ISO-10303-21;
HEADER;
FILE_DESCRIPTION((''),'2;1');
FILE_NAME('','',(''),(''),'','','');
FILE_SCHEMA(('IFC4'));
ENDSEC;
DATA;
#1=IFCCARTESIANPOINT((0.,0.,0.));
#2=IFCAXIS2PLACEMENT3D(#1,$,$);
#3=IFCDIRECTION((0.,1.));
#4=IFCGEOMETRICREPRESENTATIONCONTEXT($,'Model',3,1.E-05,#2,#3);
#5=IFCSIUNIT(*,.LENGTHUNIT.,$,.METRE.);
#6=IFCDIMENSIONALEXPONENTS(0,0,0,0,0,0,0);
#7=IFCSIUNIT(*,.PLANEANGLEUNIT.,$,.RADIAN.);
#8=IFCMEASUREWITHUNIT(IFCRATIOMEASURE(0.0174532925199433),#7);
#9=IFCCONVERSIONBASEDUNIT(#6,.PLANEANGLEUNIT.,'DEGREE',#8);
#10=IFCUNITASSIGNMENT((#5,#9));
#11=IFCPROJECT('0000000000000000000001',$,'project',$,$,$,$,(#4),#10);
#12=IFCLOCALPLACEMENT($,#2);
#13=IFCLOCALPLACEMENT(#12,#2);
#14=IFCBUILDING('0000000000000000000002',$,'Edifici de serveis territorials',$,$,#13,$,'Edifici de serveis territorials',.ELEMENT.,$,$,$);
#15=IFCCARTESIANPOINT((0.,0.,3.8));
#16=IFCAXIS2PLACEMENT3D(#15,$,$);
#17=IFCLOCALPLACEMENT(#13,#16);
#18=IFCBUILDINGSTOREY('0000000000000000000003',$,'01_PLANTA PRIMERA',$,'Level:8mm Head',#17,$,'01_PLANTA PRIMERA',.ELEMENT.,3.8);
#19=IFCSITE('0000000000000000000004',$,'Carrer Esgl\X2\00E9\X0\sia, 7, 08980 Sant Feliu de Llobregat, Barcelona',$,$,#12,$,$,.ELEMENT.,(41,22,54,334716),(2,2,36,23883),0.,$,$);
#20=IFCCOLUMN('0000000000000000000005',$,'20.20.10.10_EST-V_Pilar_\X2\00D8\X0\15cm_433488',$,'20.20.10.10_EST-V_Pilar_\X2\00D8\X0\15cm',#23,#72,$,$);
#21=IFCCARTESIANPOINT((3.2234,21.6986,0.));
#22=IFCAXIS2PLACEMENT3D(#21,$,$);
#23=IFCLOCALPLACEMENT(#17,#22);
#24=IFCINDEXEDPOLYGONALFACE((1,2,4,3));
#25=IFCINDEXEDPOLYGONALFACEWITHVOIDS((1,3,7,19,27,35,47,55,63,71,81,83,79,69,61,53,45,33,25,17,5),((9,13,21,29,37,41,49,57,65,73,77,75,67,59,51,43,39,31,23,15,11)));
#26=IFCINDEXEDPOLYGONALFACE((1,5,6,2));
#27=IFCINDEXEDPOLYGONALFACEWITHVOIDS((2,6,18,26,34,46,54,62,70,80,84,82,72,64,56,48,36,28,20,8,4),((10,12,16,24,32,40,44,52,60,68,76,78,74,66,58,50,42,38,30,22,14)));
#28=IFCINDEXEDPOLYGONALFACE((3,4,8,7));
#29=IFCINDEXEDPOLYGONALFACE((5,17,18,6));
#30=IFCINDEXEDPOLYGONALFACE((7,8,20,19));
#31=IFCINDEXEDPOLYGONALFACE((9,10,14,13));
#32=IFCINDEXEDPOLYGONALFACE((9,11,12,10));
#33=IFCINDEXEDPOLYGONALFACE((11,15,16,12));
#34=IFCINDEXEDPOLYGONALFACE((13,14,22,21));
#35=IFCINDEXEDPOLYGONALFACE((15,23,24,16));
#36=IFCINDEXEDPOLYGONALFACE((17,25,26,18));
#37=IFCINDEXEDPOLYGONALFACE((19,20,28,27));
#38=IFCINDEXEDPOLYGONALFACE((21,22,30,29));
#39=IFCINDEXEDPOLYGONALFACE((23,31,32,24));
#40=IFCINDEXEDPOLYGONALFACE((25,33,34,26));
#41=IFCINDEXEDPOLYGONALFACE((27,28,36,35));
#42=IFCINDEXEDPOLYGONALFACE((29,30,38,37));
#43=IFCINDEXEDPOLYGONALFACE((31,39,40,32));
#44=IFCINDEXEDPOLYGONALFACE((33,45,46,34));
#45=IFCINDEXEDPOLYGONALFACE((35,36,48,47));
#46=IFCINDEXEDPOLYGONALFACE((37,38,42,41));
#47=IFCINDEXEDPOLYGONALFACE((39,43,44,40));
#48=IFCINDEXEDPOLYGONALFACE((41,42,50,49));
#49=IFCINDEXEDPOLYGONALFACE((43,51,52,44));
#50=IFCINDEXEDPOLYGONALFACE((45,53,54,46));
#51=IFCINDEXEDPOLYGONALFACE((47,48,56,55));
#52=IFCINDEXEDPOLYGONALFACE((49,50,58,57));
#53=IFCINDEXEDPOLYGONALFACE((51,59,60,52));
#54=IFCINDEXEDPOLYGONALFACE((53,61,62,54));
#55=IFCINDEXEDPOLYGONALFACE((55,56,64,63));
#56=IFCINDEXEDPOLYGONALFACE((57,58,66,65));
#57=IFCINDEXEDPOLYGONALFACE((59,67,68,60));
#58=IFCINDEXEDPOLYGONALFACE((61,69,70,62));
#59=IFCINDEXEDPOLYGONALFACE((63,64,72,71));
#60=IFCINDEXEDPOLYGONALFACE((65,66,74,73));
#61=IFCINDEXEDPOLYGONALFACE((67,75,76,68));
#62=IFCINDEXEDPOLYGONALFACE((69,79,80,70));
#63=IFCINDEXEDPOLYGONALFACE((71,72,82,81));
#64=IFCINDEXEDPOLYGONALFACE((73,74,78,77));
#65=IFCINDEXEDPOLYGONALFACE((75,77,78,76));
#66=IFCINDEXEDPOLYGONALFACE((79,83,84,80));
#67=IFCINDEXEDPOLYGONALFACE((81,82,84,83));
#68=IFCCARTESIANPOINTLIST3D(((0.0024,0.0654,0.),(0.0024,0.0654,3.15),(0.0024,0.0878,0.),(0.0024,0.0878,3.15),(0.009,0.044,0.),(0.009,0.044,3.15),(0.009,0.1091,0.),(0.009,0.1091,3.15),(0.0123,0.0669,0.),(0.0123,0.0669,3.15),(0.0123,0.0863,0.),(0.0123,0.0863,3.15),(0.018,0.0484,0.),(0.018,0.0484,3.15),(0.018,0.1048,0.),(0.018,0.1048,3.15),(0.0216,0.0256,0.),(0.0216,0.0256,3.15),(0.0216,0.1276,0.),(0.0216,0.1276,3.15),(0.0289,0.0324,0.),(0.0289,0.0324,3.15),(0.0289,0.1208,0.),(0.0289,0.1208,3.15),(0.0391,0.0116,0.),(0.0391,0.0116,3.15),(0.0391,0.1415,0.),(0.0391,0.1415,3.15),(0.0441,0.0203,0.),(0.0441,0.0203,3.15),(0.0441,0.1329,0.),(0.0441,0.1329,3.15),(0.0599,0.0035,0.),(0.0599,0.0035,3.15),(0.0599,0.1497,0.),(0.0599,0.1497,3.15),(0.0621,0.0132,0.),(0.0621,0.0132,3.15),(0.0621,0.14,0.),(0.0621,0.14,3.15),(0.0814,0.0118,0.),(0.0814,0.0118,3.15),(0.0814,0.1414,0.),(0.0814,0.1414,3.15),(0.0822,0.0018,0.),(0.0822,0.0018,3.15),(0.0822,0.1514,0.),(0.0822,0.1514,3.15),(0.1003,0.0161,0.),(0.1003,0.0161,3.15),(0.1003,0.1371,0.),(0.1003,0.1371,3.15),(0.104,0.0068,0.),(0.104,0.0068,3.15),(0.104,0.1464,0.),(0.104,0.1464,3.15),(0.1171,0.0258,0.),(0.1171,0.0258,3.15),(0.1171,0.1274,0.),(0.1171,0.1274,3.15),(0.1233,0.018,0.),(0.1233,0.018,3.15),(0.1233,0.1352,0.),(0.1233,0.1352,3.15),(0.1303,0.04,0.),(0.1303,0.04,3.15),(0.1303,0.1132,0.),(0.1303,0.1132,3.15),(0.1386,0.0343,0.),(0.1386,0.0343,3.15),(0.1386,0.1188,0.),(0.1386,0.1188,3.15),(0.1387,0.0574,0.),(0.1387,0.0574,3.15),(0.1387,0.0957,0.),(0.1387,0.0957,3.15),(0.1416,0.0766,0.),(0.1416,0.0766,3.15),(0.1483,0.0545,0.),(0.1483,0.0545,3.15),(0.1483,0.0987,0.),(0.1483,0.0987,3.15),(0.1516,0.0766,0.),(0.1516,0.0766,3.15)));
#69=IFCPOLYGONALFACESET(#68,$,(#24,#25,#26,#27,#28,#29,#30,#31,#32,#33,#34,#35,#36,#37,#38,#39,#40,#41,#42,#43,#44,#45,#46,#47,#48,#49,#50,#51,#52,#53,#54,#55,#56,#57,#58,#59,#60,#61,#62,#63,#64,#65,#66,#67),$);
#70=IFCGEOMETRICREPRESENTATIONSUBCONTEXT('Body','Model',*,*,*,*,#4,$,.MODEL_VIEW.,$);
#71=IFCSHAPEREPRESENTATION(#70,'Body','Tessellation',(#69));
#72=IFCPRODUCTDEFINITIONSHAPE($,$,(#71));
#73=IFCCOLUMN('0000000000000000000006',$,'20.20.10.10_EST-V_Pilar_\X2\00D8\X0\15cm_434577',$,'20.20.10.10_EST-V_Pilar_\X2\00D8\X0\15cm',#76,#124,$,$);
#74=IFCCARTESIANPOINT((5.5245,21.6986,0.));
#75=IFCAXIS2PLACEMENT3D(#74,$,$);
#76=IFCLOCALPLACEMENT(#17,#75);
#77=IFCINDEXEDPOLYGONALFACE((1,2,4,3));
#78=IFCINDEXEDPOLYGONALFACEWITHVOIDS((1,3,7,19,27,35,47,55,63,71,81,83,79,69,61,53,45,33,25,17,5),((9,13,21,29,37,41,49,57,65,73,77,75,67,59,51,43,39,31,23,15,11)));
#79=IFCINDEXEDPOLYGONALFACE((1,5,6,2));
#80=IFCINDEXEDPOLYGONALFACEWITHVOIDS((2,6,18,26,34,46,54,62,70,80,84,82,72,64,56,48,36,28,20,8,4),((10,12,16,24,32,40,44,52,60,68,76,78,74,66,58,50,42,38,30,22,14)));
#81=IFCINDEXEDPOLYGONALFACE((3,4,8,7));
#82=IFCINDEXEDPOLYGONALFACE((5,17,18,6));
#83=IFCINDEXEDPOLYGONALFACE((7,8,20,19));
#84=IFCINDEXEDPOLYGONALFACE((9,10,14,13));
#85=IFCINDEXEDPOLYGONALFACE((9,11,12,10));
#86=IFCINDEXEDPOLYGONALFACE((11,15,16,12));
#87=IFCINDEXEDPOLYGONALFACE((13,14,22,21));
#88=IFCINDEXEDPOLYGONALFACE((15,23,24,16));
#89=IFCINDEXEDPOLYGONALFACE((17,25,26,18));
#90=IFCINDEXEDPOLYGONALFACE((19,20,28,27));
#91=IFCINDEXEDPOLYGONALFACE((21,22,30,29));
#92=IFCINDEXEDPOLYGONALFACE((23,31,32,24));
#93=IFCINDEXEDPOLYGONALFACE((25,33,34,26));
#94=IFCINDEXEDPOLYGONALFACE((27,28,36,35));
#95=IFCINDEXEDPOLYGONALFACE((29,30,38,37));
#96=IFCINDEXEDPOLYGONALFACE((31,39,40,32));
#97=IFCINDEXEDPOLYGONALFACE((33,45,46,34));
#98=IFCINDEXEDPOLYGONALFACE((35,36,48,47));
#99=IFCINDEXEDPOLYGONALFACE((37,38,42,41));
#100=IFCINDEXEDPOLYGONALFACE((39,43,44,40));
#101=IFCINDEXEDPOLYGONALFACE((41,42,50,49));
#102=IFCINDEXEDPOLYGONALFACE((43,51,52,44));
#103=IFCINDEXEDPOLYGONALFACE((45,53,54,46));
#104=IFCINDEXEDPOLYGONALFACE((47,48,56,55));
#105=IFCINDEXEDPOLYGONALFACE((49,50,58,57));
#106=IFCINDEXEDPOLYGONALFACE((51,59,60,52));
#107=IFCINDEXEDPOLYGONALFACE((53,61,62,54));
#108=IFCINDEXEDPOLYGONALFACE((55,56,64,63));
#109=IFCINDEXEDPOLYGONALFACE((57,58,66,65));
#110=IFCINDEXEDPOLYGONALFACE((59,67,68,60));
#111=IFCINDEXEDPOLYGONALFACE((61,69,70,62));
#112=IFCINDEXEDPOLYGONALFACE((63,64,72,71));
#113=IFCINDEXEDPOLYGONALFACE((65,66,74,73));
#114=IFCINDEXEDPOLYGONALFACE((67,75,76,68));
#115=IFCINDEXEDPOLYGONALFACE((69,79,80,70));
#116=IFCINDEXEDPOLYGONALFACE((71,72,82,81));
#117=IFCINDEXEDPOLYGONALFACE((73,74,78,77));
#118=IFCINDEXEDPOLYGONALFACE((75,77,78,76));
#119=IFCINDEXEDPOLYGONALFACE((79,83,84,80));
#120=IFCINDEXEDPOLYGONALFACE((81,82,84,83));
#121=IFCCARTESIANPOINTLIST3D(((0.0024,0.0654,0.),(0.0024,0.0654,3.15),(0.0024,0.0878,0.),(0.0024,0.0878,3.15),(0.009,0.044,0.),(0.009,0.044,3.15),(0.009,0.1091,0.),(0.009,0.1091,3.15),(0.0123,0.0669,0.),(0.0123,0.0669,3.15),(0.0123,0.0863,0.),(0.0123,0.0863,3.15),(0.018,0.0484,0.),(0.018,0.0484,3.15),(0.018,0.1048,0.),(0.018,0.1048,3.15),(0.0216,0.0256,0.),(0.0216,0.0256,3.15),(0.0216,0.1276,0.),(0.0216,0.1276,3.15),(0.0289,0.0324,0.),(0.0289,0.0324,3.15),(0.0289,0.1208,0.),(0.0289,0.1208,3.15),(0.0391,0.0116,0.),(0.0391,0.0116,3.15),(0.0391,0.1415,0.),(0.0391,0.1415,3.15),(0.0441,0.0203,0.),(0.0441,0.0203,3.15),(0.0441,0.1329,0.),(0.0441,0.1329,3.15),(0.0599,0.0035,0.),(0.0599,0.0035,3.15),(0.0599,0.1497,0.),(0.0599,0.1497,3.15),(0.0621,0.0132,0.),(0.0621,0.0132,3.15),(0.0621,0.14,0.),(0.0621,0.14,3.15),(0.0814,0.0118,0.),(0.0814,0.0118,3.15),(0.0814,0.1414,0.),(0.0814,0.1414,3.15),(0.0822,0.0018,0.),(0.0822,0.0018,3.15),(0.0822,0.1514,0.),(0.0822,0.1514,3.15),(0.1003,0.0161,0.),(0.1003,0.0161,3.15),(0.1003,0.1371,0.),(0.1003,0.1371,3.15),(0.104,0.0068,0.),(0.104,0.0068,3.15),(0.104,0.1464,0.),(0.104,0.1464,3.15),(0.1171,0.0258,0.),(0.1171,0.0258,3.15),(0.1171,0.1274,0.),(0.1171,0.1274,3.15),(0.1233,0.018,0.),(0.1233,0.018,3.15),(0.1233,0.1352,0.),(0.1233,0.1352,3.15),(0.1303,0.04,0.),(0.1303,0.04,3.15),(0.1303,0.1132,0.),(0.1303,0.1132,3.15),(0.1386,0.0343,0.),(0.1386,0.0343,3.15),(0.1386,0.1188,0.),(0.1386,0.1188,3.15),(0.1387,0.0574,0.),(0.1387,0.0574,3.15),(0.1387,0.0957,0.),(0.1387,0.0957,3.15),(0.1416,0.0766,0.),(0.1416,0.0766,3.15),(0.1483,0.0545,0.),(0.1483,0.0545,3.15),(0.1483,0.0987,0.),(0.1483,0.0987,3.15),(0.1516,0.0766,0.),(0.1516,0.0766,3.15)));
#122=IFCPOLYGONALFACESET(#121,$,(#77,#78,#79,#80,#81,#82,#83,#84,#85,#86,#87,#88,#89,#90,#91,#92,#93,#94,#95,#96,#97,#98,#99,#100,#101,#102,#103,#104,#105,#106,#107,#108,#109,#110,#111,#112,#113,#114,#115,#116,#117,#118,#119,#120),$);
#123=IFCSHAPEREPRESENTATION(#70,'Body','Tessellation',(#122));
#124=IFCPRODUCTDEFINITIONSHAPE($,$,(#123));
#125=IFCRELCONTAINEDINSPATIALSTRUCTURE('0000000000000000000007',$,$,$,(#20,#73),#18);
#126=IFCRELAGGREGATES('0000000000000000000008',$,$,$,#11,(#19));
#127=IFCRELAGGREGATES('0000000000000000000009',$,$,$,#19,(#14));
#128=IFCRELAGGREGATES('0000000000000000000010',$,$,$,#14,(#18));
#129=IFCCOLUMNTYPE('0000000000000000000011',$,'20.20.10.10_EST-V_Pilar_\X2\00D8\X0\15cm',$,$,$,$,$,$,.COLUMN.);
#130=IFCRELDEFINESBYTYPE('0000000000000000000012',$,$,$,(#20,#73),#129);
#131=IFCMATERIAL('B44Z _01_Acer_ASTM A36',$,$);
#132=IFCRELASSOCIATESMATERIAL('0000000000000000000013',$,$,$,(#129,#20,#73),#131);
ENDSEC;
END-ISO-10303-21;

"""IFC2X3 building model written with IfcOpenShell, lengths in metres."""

from ifc_helpers import new_model, entity, si_unit, converted_unit, direction, frame, frame_2d, origin, place, context, subcontext, project, spatial, hollow_circle, extrude, source, transform, mapped, material, type_object, type_shapes, element, save


model = new_model("IFC2X3")

# Units and contexts
model_context = context("Model", 3, precision=1e-05, world=origin(), true_north=direction((0.0, 1.0)))
body_context = subcontext(model_context, "Body", "Model", "MODEL_VIEW")
ifc_project = project(units=[si_unit("LENGTHUNIT", "METRE"), converted_unit("PLANEANGLEUNIT", "DEGREE", entity("IfcRatioMeasure", 0.0174532925199433), si_unit("PLANEANGLEUNIT", "RADIAN"), dimensions=[0, 0, 0, 0, 0, 0, 0])], contexts=[model_context])

# Site, building, storey
site_placement = place(None, origin())
site = spatial("IfcSite", under=ifc_project, at=site_placement, Name="Carrer Església, 7, 08980 Sant Feliu de Llobregat, Barcelona", CompositionType="ELEMENT", RefLatitude=(41, 22, 54, 334716), RefLongitude=(2, 2, 36, 23883), RefElevation=0.0)
building_placement = place(site_placement, origin())
building = spatial("IfcBuilding", under=site, at=building_placement, Name="Edifici de serveis territorials", LongName="Edifici de serveis territorials", CompositionType="ELEMENT")
storey_placement = place(building_placement, frame((0.0, 0.0, 3.8)))
storey = spatial("IfcBuildingStorey", under=building, at=storey_placement, Name="01_PLANTA PRIMERA", ObjectType="Level:8mm Head", LongName="01_PLANTA PRIMERA", CompositionType="ELEMENT", Elevation=3.8)

# Columns
ifc_material_1 = material(Name="B44Z _01_Acer_ASTM A36")
column_type = type_object("IfcColumnType", Name="20.20.10.10_EST-V_Pilar_Ø15cm", PredefinedType="COLUMN", material=ifc_material_1)
shared_shape_1 = source(origin(), body_context, "Body", "SweptSolid", [
    extrude(hollow_circle(Radius=0.075, WallThickness=0.01, at=frame_2d((0.0, 0.0), x_axis=(1.0, 0.0))), frame((0.0766, 0.0766, 0.0)), (0.0, 0.0, 1.0), 3.15),
])
type_shapes(column_type, [shared_shape_1])
for number, where, name in (
    (1, (3.2234, 21.6986, 0.0), "20.20.10.10_EST-V_Pilar_Ø15cm_433488"),
    (2, (5.5245, 21.6986, 0.0), "20.20.10.10_EST-V_Pilar_Ø15cm_434577"),
):
    element("IfcColumn", number, at=place(storey_placement, frame(where)), inside=storey, type_object=column_type, material=ifc_material_1, Name=name, ObjectType="20.20.10.10_EST-V_Pilar_Ø15cm", context=body_context, shape_type="MappedRepresentation", body=[
        mapped(shared_shape_1, transform((0.0, 0.0, 0.0), scale=1.0)),
    ])

save(model, "model.ifc")
